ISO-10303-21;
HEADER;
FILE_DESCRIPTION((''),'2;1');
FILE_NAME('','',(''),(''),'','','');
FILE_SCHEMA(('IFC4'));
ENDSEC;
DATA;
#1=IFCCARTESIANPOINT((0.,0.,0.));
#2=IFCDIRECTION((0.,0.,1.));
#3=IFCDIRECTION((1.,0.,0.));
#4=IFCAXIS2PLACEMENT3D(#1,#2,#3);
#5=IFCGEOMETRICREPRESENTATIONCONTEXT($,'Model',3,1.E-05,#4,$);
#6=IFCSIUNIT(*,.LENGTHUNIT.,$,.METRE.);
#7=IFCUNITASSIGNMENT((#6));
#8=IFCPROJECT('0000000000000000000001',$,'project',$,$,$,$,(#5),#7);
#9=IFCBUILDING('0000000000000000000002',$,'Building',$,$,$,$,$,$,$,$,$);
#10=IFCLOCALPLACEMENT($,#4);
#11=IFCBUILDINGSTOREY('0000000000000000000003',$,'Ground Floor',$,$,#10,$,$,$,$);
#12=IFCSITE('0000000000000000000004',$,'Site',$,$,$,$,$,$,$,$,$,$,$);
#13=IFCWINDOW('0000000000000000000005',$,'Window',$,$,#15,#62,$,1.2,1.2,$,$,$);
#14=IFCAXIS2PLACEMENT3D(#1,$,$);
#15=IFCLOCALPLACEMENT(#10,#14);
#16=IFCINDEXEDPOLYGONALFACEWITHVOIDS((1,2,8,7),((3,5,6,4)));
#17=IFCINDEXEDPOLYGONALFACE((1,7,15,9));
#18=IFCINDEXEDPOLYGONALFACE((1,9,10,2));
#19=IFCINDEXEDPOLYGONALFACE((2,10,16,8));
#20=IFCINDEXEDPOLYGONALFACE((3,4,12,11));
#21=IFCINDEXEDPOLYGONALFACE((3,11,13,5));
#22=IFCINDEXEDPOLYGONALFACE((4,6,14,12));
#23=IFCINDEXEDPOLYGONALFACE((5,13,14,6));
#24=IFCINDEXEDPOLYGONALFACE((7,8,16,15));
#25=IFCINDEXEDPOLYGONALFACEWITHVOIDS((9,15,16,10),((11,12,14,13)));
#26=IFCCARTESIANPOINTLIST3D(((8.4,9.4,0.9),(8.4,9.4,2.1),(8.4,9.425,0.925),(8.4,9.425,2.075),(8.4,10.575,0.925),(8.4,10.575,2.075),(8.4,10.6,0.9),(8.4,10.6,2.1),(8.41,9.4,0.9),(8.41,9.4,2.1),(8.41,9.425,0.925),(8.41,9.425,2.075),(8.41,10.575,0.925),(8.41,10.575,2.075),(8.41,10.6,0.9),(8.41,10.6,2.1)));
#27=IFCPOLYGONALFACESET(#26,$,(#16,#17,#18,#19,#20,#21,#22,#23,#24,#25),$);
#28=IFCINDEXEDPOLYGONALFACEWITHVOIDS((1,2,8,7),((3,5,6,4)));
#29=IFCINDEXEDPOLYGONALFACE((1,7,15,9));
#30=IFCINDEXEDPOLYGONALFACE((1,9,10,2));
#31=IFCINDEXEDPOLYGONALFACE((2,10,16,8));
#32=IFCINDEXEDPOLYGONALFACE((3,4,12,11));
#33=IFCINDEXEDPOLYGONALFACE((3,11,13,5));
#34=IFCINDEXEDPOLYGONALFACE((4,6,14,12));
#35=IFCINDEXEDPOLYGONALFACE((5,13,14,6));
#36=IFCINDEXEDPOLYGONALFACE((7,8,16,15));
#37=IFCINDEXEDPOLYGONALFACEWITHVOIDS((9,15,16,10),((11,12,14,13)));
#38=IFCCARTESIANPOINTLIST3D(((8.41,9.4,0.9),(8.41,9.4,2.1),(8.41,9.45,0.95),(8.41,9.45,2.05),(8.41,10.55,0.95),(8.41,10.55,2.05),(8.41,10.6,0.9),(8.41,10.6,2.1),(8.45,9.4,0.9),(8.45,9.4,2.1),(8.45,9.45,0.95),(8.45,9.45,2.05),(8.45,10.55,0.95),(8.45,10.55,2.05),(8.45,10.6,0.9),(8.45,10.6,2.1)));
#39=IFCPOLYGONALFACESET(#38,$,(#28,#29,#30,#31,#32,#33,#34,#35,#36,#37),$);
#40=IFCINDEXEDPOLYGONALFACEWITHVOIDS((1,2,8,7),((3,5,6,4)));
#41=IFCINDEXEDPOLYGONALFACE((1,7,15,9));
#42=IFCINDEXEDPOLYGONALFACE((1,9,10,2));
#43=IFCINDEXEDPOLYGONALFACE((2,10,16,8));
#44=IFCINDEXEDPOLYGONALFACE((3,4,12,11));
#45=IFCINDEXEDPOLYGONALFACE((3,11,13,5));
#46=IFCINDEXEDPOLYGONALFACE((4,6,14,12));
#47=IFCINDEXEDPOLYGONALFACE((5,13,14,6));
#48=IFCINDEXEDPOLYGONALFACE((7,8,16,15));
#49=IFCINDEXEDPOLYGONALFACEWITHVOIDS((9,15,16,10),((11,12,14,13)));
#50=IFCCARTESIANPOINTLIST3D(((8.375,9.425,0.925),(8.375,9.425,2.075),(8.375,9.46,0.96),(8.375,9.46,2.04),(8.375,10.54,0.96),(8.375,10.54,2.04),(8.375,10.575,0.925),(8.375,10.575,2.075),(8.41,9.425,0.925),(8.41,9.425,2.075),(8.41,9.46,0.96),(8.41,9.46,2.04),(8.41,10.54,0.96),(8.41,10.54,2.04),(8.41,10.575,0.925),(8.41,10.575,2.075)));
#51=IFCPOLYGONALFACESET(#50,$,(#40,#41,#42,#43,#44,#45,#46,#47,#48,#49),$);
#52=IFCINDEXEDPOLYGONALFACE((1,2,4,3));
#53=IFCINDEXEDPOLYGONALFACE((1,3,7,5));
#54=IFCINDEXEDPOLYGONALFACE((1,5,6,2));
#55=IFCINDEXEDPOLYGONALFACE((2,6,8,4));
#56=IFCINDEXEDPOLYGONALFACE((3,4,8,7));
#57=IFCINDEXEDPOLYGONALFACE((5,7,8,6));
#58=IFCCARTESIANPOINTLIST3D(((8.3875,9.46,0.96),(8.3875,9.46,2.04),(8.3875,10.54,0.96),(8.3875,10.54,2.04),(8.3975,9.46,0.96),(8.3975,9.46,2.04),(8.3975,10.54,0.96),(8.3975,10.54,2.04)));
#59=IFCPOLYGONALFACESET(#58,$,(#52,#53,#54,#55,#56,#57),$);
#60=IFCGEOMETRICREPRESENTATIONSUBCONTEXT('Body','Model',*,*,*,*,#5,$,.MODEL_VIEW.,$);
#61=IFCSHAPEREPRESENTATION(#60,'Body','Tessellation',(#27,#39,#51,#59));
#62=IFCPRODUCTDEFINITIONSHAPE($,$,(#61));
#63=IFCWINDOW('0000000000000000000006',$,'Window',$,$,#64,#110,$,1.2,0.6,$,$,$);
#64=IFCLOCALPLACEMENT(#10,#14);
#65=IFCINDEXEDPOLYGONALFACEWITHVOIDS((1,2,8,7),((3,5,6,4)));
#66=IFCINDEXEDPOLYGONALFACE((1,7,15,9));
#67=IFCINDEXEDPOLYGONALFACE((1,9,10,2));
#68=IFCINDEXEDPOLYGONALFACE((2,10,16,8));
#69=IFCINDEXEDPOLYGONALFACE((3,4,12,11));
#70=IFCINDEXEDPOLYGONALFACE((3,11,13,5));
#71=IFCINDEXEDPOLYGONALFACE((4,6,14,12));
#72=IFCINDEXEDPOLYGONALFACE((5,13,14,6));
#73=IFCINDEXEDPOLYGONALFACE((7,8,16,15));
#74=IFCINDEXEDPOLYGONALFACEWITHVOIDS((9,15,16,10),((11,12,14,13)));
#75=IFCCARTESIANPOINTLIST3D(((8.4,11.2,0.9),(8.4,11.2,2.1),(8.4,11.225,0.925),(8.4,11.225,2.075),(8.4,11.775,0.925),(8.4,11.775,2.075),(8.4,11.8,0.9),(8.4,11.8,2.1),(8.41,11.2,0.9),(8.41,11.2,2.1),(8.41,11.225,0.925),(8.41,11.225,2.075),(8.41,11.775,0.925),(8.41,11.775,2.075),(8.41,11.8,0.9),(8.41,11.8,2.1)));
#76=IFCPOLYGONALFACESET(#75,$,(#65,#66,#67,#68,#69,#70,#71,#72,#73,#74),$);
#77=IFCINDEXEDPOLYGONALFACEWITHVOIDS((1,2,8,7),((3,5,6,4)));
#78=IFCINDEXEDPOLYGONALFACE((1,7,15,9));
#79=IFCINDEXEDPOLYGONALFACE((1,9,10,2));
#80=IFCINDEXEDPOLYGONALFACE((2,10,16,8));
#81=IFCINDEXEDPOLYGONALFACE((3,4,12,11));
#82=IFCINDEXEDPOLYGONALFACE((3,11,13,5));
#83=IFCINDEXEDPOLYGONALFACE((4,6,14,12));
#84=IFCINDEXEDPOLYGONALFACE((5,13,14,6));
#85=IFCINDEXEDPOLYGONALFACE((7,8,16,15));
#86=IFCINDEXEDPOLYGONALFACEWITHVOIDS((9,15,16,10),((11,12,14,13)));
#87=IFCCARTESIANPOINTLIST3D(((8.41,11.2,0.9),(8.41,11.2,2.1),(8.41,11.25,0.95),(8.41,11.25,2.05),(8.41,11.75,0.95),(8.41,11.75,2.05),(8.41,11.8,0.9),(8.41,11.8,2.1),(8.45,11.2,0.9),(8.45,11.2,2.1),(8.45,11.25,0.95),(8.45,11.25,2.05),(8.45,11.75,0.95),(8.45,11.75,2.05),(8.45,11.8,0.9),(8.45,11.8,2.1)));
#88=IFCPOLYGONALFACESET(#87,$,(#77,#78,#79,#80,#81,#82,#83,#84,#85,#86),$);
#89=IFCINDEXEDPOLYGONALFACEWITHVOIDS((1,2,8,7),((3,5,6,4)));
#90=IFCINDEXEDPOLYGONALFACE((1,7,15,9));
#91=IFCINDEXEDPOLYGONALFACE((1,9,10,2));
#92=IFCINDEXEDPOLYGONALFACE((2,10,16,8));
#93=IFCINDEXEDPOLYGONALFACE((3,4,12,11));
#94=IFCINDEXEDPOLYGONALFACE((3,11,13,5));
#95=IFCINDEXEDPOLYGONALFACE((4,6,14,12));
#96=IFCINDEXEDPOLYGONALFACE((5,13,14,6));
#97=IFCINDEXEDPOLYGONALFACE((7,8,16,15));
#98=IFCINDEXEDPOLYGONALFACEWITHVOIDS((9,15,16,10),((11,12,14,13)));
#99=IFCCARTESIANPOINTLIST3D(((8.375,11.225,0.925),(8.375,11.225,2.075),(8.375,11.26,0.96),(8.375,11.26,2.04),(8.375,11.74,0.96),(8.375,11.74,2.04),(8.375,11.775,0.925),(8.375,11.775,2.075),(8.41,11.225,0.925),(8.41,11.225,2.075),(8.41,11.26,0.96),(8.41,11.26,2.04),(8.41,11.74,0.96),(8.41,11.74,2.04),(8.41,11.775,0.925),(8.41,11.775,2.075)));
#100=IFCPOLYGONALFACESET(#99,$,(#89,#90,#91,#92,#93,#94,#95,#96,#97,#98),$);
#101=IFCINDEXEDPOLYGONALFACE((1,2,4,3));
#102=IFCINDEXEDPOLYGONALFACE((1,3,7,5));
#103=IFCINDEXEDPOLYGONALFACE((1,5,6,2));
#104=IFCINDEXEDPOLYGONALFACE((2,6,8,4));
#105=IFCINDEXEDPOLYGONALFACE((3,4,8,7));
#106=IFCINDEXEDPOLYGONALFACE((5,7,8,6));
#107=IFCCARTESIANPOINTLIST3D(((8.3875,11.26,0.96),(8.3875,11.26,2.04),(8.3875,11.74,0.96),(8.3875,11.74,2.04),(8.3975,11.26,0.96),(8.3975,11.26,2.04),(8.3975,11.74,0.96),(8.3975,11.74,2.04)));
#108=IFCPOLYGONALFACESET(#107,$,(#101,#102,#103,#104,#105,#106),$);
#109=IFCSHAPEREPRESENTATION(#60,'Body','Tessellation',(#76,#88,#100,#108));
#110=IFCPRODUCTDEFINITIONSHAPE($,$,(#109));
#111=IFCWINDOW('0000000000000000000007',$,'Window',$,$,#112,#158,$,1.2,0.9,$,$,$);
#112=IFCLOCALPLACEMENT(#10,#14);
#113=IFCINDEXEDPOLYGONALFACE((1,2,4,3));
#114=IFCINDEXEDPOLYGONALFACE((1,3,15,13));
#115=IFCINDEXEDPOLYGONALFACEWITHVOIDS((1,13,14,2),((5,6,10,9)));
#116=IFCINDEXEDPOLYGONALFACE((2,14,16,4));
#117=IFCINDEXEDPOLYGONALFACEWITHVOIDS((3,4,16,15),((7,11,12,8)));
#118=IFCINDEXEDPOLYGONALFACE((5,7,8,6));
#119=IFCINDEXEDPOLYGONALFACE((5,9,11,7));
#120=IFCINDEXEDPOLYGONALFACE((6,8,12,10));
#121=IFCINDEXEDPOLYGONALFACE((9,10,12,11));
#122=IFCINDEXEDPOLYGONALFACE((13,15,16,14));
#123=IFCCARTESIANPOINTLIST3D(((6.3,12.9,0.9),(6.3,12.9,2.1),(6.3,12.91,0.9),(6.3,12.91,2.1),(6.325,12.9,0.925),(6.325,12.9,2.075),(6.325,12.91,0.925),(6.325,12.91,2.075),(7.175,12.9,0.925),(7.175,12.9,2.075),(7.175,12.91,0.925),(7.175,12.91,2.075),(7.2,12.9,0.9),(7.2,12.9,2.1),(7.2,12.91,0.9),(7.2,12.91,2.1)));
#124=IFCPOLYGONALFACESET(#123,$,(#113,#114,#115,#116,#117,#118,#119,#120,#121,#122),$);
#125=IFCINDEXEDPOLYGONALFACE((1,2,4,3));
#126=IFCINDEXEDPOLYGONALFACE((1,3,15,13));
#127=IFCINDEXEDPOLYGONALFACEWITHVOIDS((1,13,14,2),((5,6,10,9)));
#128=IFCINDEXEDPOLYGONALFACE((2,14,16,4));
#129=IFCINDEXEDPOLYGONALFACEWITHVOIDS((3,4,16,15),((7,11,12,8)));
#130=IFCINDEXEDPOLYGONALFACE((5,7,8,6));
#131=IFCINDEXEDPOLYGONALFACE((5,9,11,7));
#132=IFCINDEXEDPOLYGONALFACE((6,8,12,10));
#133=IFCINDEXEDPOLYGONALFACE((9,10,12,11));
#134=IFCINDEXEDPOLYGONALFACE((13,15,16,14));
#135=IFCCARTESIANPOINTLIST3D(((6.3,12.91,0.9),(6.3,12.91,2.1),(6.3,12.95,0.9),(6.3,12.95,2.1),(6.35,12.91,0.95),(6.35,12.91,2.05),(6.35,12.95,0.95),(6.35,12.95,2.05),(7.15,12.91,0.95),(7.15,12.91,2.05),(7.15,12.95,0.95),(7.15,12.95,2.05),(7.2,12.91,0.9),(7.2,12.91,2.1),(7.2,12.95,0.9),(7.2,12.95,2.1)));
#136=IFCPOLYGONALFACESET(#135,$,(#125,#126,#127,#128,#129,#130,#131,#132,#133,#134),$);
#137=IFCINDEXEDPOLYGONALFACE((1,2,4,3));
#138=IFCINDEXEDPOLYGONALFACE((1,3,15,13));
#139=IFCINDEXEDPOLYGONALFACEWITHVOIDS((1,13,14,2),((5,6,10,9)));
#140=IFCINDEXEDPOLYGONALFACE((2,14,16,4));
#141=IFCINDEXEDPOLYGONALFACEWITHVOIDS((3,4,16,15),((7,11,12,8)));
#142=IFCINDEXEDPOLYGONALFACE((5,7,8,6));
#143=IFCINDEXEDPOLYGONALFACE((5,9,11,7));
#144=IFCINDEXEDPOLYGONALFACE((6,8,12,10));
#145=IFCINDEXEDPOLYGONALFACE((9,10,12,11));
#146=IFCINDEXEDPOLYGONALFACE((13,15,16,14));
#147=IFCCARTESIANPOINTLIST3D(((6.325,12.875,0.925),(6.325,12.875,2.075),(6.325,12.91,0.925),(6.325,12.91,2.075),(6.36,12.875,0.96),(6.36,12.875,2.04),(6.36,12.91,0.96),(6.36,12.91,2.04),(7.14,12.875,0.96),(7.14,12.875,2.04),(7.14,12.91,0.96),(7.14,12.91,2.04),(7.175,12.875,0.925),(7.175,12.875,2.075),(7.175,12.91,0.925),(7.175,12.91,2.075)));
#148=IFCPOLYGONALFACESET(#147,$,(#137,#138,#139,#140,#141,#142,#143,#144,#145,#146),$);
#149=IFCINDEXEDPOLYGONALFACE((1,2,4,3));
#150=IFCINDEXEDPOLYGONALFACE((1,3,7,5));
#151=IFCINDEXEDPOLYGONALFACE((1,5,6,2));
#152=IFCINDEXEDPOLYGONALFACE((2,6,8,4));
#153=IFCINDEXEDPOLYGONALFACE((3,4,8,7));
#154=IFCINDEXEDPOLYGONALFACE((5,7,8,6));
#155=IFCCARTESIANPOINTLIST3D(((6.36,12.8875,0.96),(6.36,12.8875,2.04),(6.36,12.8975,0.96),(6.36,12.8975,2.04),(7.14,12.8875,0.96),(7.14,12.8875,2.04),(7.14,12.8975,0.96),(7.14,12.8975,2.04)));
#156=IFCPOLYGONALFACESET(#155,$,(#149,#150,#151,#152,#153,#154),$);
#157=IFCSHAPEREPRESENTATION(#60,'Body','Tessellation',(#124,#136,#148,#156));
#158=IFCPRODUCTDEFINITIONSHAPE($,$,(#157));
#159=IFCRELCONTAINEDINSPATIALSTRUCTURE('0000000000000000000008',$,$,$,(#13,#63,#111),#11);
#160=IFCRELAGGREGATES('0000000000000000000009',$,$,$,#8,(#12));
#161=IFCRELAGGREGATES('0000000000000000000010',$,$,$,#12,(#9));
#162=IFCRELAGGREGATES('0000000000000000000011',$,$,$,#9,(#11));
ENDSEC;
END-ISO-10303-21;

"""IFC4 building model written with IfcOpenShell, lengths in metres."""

from ifc_helpers import new_model, si_unit, frame, origin_with_axes, place, context, subcontext, project, spatial, line, indexed_curve, outline, extrude, element, save


model = new_model("IFC4")

# Units and contexts
model_context = context("Model", 3, precision=1e-05, world=origin_with_axes())
body_context = subcontext(model_context, "Body", "Model", "MODEL_VIEW")
ifc_project = project(units=[si_unit("LENGTHUNIT", "METRE")], contexts=[model_context])

# Site, building, storey
site = spatial("IfcSite", under=ifc_project, Name="Site")
building = spatial("IfcBuilding", under=site, Name="Building")
storey_placement = place(None, origin_with_axes())
storey = spatial("IfcBuildingStorey", under=building, at=storey_placement, Name="Ground Floor")

# Windows
window_1_placement = place(storey_placement, frame((8.5, 9.4, 0.9), z_axis=(0.0, 0.0, 1.0), x_axis=(0.0, 1.0, 0.0)))
element("IfcWindow", 1, at=window_1_placement, inside=storey, Name="Window", OverallHeight=1.2, OverallWidth=1.2, context=body_context, shape_type="SweptSolid", body=[
    extrude(outline(indexed_curve([(0.0, 0.0), (1.2, 0.0), (1.2, 1.2), (0.0, 1.2)], segments=[line(1, 2, 3, 4, 1)]), holes=[indexed_curve([(0.025, 0.025), (1.175, 0.025), (1.175, 1.175), (0.025, 1.175)], segments=[line(1, 2, 3, 4, 1)])]), frame((0.0, 0.09, 0.0), z_axis=(0.0, -1.0, 0.0), x_axis=(1.0, 0.0, 0.0)), (0.0, 0.0, -1.0), 0.01),
    extrude(outline(indexed_curve([(0.0, 0.0), (1.2, 0.0), (1.2, 1.2), (0.0, 1.2)], segments=[line(1, 2, 3, 4, 1)]), holes=[indexed_curve([(0.05, 0.05), (1.15, 0.05), (1.15, 1.15), (0.05, 1.15)], segments=[line(1, 2, 3, 4, 1)])]), frame((0.0, 0.05, 0.0), z_axis=(0.0, -1.0, 0.0), x_axis=(1.0, 0.0, 0.0)), (0.0, 0.0, -1.0), 0.04),
    extrude(outline(indexed_curve([(0.0, 0.0), (1.15, 0.0), (1.15, 1.15), (0.0, 1.15)], segments=[line(1, 2, 3, 4, 1)]), holes=[indexed_curve([(0.035, 0.035), (1.115, 0.035), (1.115, 1.115), (0.035, 1.115)], segments=[line(1, 2, 3, 4, 1)])]), frame((0.025, 0.09, 0.025), z_axis=(0.0, -1.0, 0.0), x_axis=(1.0, 0.0, 0.0)), (0.0, 0.0, -1.0), 0.035),
    extrude(outline(indexed_curve([(0.035, 0.035), (1.115, 0.035), (1.115, 1.115), (0.035, 1.115)], segments=[line(1, 2, 3, 4, 1)])), frame((0.025, 0.1025, 0.025), z_axis=(0.0, -1.0, 0.0), x_axis=(1.0, 0.0, 0.0)), (0.0, 0.0, -1.0), 0.01),
])
window_2_placement = place(storey_placement, frame((8.5, 11.2, 0.9), z_axis=(0.0, 0.0, 1.0), x_axis=(0.0, 1.0, 0.0)))
element("IfcWindow", 2, at=window_2_placement, inside=storey, Name="Window", OverallHeight=1.2, OverallWidth=0.6, context=body_context, shape_type="SweptSolid", body=[
    extrude(outline(indexed_curve([(0.0, 0.0), (0.6, 0.0), (0.6, 1.2), (0.0, 1.2)], segments=[line(1, 2, 3, 4, 1)]), holes=[indexed_curve([(0.025, 0.025), (0.575, 0.025), (0.575, 1.175), (0.025, 1.175)], segments=[line(1, 2, 3, 4, 1)])]), frame((0.0, 0.09, 0.0), z_axis=(0.0, -1.0, 0.0), x_axis=(1.0, 0.0, 0.0)), (0.0, 0.0, -1.0), 0.01),
    extrude(outline(indexed_curve([(0.0, 0.0), (0.6, 0.0), (0.6, 1.2), (0.0, 1.2)], segments=[line(1, 2, 3, 4, 1)]), holes=[indexed_curve([(0.05, 0.05), (0.55, 0.05), (0.55, 1.15), (0.05, 1.15)], segments=[line(1, 2, 3, 4, 1)])]), frame((0.0, 0.05, 0.0), z_axis=(0.0, -1.0, 0.0), x_axis=(1.0, 0.0, 0.0)), (0.0, 0.0, -1.0), 0.04),
    extrude(outline(indexed_curve([(0.0, 0.0), (0.55, 0.0), (0.55, 1.15), (0.0, 1.15)], segments=[line(1, 2, 3, 4, 1)]), holes=[indexed_curve([(0.035, 0.035), (0.515, 0.035), (0.515, 1.115), (0.035, 1.115)], segments=[line(1, 2, 3, 4, 1)])]), frame((0.025, 0.09, 0.025), z_axis=(0.0, -1.0, 0.0), x_axis=(1.0, 0.0, 0.0)), (0.0, 0.0, -1.0), 0.035),
    extrude(outline(indexed_curve([(0.035, 0.035), (0.515, 0.035), (0.515, 1.115), (0.035, 1.115)], segments=[line(1, 2, 3, 4, 1)])), frame((0.025, 0.1025, 0.025), z_axis=(0.0, -1.0, 0.0), x_axis=(1.0, 0.0, 0.0)), (0.0, 0.0, -1.0), 0.01),
])
window_3_placement = place(storey_placement, frame((7.2, 13.0, 0.9), z_axis=(0.0, 0.0, 1.0), x_axis=(-1.0, 0.0, 0.0)))
element("IfcWindow", 3, at=window_3_placement, inside=storey, Name="Window", OverallHeight=1.2, OverallWidth=0.9, context=body_context, shape_type="SweptSolid", body=[
    extrude(outline(indexed_curve([(0.0, 0.0), (0.9, 0.0), (0.9, 1.2), (0.0, 1.2)], segments=[line(1, 2, 3, 4, 1)]), holes=[indexed_curve([(0.025, 0.025), (0.875, 0.025), (0.875, 1.175), (0.025, 1.175)], segments=[line(1, 2, 3, 4, 1)])]), frame((0.0, 0.09, 0.0), z_axis=(0.0, -1.0, 0.0), x_axis=(1.0, 0.0, 0.0)), (0.0, 0.0, -1.0), 0.01),
    extrude(outline(indexed_curve([(0.0, 0.0), (0.9, 0.0), (0.9, 1.2), (0.0, 1.2)], segments=[line(1, 2, 3, 4, 1)]), holes=[indexed_curve([(0.05, 0.05), (0.85, 0.05), (0.85, 1.15), (0.05, 1.15)], segments=[line(1, 2, 3, 4, 1)])]), frame((0.0, 0.05, 0.0), z_axis=(0.0, -1.0, 0.0), x_axis=(1.0, 0.0, 0.0)), (0.0, 0.0, -1.0), 0.04),
    extrude(outline(indexed_curve([(0.0, 0.0), (0.85, 0.0), (0.85, 1.15), (0.0, 1.15)], segments=[line(1, 2, 3, 4, 1)]), holes=[indexed_curve([(0.035, 0.035), (0.815, 0.035), (0.815, 1.115), (0.035, 1.115)], segments=[line(1, 2, 3, 4, 1)])]), frame((0.025, 0.09, 0.025), z_axis=(0.0, -1.0, 0.0), x_axis=(1.0, 0.0, 0.0)), (0.0, 0.0, -1.0), 0.035),
    extrude(outline(indexed_curve([(0.035, 0.035), (0.815, 0.035), (0.815, 1.115), (0.035, 1.115)], segments=[line(1, 2, 3, 4, 1)])), frame((0.025, 0.1025, 0.025), z_axis=(0.0, -1.0, 0.0), x_axis=(1.0, 0.0, 0.0)), (0.0, 0.0, -1.0), 0.01),
])

save(model, "model.ifc")
